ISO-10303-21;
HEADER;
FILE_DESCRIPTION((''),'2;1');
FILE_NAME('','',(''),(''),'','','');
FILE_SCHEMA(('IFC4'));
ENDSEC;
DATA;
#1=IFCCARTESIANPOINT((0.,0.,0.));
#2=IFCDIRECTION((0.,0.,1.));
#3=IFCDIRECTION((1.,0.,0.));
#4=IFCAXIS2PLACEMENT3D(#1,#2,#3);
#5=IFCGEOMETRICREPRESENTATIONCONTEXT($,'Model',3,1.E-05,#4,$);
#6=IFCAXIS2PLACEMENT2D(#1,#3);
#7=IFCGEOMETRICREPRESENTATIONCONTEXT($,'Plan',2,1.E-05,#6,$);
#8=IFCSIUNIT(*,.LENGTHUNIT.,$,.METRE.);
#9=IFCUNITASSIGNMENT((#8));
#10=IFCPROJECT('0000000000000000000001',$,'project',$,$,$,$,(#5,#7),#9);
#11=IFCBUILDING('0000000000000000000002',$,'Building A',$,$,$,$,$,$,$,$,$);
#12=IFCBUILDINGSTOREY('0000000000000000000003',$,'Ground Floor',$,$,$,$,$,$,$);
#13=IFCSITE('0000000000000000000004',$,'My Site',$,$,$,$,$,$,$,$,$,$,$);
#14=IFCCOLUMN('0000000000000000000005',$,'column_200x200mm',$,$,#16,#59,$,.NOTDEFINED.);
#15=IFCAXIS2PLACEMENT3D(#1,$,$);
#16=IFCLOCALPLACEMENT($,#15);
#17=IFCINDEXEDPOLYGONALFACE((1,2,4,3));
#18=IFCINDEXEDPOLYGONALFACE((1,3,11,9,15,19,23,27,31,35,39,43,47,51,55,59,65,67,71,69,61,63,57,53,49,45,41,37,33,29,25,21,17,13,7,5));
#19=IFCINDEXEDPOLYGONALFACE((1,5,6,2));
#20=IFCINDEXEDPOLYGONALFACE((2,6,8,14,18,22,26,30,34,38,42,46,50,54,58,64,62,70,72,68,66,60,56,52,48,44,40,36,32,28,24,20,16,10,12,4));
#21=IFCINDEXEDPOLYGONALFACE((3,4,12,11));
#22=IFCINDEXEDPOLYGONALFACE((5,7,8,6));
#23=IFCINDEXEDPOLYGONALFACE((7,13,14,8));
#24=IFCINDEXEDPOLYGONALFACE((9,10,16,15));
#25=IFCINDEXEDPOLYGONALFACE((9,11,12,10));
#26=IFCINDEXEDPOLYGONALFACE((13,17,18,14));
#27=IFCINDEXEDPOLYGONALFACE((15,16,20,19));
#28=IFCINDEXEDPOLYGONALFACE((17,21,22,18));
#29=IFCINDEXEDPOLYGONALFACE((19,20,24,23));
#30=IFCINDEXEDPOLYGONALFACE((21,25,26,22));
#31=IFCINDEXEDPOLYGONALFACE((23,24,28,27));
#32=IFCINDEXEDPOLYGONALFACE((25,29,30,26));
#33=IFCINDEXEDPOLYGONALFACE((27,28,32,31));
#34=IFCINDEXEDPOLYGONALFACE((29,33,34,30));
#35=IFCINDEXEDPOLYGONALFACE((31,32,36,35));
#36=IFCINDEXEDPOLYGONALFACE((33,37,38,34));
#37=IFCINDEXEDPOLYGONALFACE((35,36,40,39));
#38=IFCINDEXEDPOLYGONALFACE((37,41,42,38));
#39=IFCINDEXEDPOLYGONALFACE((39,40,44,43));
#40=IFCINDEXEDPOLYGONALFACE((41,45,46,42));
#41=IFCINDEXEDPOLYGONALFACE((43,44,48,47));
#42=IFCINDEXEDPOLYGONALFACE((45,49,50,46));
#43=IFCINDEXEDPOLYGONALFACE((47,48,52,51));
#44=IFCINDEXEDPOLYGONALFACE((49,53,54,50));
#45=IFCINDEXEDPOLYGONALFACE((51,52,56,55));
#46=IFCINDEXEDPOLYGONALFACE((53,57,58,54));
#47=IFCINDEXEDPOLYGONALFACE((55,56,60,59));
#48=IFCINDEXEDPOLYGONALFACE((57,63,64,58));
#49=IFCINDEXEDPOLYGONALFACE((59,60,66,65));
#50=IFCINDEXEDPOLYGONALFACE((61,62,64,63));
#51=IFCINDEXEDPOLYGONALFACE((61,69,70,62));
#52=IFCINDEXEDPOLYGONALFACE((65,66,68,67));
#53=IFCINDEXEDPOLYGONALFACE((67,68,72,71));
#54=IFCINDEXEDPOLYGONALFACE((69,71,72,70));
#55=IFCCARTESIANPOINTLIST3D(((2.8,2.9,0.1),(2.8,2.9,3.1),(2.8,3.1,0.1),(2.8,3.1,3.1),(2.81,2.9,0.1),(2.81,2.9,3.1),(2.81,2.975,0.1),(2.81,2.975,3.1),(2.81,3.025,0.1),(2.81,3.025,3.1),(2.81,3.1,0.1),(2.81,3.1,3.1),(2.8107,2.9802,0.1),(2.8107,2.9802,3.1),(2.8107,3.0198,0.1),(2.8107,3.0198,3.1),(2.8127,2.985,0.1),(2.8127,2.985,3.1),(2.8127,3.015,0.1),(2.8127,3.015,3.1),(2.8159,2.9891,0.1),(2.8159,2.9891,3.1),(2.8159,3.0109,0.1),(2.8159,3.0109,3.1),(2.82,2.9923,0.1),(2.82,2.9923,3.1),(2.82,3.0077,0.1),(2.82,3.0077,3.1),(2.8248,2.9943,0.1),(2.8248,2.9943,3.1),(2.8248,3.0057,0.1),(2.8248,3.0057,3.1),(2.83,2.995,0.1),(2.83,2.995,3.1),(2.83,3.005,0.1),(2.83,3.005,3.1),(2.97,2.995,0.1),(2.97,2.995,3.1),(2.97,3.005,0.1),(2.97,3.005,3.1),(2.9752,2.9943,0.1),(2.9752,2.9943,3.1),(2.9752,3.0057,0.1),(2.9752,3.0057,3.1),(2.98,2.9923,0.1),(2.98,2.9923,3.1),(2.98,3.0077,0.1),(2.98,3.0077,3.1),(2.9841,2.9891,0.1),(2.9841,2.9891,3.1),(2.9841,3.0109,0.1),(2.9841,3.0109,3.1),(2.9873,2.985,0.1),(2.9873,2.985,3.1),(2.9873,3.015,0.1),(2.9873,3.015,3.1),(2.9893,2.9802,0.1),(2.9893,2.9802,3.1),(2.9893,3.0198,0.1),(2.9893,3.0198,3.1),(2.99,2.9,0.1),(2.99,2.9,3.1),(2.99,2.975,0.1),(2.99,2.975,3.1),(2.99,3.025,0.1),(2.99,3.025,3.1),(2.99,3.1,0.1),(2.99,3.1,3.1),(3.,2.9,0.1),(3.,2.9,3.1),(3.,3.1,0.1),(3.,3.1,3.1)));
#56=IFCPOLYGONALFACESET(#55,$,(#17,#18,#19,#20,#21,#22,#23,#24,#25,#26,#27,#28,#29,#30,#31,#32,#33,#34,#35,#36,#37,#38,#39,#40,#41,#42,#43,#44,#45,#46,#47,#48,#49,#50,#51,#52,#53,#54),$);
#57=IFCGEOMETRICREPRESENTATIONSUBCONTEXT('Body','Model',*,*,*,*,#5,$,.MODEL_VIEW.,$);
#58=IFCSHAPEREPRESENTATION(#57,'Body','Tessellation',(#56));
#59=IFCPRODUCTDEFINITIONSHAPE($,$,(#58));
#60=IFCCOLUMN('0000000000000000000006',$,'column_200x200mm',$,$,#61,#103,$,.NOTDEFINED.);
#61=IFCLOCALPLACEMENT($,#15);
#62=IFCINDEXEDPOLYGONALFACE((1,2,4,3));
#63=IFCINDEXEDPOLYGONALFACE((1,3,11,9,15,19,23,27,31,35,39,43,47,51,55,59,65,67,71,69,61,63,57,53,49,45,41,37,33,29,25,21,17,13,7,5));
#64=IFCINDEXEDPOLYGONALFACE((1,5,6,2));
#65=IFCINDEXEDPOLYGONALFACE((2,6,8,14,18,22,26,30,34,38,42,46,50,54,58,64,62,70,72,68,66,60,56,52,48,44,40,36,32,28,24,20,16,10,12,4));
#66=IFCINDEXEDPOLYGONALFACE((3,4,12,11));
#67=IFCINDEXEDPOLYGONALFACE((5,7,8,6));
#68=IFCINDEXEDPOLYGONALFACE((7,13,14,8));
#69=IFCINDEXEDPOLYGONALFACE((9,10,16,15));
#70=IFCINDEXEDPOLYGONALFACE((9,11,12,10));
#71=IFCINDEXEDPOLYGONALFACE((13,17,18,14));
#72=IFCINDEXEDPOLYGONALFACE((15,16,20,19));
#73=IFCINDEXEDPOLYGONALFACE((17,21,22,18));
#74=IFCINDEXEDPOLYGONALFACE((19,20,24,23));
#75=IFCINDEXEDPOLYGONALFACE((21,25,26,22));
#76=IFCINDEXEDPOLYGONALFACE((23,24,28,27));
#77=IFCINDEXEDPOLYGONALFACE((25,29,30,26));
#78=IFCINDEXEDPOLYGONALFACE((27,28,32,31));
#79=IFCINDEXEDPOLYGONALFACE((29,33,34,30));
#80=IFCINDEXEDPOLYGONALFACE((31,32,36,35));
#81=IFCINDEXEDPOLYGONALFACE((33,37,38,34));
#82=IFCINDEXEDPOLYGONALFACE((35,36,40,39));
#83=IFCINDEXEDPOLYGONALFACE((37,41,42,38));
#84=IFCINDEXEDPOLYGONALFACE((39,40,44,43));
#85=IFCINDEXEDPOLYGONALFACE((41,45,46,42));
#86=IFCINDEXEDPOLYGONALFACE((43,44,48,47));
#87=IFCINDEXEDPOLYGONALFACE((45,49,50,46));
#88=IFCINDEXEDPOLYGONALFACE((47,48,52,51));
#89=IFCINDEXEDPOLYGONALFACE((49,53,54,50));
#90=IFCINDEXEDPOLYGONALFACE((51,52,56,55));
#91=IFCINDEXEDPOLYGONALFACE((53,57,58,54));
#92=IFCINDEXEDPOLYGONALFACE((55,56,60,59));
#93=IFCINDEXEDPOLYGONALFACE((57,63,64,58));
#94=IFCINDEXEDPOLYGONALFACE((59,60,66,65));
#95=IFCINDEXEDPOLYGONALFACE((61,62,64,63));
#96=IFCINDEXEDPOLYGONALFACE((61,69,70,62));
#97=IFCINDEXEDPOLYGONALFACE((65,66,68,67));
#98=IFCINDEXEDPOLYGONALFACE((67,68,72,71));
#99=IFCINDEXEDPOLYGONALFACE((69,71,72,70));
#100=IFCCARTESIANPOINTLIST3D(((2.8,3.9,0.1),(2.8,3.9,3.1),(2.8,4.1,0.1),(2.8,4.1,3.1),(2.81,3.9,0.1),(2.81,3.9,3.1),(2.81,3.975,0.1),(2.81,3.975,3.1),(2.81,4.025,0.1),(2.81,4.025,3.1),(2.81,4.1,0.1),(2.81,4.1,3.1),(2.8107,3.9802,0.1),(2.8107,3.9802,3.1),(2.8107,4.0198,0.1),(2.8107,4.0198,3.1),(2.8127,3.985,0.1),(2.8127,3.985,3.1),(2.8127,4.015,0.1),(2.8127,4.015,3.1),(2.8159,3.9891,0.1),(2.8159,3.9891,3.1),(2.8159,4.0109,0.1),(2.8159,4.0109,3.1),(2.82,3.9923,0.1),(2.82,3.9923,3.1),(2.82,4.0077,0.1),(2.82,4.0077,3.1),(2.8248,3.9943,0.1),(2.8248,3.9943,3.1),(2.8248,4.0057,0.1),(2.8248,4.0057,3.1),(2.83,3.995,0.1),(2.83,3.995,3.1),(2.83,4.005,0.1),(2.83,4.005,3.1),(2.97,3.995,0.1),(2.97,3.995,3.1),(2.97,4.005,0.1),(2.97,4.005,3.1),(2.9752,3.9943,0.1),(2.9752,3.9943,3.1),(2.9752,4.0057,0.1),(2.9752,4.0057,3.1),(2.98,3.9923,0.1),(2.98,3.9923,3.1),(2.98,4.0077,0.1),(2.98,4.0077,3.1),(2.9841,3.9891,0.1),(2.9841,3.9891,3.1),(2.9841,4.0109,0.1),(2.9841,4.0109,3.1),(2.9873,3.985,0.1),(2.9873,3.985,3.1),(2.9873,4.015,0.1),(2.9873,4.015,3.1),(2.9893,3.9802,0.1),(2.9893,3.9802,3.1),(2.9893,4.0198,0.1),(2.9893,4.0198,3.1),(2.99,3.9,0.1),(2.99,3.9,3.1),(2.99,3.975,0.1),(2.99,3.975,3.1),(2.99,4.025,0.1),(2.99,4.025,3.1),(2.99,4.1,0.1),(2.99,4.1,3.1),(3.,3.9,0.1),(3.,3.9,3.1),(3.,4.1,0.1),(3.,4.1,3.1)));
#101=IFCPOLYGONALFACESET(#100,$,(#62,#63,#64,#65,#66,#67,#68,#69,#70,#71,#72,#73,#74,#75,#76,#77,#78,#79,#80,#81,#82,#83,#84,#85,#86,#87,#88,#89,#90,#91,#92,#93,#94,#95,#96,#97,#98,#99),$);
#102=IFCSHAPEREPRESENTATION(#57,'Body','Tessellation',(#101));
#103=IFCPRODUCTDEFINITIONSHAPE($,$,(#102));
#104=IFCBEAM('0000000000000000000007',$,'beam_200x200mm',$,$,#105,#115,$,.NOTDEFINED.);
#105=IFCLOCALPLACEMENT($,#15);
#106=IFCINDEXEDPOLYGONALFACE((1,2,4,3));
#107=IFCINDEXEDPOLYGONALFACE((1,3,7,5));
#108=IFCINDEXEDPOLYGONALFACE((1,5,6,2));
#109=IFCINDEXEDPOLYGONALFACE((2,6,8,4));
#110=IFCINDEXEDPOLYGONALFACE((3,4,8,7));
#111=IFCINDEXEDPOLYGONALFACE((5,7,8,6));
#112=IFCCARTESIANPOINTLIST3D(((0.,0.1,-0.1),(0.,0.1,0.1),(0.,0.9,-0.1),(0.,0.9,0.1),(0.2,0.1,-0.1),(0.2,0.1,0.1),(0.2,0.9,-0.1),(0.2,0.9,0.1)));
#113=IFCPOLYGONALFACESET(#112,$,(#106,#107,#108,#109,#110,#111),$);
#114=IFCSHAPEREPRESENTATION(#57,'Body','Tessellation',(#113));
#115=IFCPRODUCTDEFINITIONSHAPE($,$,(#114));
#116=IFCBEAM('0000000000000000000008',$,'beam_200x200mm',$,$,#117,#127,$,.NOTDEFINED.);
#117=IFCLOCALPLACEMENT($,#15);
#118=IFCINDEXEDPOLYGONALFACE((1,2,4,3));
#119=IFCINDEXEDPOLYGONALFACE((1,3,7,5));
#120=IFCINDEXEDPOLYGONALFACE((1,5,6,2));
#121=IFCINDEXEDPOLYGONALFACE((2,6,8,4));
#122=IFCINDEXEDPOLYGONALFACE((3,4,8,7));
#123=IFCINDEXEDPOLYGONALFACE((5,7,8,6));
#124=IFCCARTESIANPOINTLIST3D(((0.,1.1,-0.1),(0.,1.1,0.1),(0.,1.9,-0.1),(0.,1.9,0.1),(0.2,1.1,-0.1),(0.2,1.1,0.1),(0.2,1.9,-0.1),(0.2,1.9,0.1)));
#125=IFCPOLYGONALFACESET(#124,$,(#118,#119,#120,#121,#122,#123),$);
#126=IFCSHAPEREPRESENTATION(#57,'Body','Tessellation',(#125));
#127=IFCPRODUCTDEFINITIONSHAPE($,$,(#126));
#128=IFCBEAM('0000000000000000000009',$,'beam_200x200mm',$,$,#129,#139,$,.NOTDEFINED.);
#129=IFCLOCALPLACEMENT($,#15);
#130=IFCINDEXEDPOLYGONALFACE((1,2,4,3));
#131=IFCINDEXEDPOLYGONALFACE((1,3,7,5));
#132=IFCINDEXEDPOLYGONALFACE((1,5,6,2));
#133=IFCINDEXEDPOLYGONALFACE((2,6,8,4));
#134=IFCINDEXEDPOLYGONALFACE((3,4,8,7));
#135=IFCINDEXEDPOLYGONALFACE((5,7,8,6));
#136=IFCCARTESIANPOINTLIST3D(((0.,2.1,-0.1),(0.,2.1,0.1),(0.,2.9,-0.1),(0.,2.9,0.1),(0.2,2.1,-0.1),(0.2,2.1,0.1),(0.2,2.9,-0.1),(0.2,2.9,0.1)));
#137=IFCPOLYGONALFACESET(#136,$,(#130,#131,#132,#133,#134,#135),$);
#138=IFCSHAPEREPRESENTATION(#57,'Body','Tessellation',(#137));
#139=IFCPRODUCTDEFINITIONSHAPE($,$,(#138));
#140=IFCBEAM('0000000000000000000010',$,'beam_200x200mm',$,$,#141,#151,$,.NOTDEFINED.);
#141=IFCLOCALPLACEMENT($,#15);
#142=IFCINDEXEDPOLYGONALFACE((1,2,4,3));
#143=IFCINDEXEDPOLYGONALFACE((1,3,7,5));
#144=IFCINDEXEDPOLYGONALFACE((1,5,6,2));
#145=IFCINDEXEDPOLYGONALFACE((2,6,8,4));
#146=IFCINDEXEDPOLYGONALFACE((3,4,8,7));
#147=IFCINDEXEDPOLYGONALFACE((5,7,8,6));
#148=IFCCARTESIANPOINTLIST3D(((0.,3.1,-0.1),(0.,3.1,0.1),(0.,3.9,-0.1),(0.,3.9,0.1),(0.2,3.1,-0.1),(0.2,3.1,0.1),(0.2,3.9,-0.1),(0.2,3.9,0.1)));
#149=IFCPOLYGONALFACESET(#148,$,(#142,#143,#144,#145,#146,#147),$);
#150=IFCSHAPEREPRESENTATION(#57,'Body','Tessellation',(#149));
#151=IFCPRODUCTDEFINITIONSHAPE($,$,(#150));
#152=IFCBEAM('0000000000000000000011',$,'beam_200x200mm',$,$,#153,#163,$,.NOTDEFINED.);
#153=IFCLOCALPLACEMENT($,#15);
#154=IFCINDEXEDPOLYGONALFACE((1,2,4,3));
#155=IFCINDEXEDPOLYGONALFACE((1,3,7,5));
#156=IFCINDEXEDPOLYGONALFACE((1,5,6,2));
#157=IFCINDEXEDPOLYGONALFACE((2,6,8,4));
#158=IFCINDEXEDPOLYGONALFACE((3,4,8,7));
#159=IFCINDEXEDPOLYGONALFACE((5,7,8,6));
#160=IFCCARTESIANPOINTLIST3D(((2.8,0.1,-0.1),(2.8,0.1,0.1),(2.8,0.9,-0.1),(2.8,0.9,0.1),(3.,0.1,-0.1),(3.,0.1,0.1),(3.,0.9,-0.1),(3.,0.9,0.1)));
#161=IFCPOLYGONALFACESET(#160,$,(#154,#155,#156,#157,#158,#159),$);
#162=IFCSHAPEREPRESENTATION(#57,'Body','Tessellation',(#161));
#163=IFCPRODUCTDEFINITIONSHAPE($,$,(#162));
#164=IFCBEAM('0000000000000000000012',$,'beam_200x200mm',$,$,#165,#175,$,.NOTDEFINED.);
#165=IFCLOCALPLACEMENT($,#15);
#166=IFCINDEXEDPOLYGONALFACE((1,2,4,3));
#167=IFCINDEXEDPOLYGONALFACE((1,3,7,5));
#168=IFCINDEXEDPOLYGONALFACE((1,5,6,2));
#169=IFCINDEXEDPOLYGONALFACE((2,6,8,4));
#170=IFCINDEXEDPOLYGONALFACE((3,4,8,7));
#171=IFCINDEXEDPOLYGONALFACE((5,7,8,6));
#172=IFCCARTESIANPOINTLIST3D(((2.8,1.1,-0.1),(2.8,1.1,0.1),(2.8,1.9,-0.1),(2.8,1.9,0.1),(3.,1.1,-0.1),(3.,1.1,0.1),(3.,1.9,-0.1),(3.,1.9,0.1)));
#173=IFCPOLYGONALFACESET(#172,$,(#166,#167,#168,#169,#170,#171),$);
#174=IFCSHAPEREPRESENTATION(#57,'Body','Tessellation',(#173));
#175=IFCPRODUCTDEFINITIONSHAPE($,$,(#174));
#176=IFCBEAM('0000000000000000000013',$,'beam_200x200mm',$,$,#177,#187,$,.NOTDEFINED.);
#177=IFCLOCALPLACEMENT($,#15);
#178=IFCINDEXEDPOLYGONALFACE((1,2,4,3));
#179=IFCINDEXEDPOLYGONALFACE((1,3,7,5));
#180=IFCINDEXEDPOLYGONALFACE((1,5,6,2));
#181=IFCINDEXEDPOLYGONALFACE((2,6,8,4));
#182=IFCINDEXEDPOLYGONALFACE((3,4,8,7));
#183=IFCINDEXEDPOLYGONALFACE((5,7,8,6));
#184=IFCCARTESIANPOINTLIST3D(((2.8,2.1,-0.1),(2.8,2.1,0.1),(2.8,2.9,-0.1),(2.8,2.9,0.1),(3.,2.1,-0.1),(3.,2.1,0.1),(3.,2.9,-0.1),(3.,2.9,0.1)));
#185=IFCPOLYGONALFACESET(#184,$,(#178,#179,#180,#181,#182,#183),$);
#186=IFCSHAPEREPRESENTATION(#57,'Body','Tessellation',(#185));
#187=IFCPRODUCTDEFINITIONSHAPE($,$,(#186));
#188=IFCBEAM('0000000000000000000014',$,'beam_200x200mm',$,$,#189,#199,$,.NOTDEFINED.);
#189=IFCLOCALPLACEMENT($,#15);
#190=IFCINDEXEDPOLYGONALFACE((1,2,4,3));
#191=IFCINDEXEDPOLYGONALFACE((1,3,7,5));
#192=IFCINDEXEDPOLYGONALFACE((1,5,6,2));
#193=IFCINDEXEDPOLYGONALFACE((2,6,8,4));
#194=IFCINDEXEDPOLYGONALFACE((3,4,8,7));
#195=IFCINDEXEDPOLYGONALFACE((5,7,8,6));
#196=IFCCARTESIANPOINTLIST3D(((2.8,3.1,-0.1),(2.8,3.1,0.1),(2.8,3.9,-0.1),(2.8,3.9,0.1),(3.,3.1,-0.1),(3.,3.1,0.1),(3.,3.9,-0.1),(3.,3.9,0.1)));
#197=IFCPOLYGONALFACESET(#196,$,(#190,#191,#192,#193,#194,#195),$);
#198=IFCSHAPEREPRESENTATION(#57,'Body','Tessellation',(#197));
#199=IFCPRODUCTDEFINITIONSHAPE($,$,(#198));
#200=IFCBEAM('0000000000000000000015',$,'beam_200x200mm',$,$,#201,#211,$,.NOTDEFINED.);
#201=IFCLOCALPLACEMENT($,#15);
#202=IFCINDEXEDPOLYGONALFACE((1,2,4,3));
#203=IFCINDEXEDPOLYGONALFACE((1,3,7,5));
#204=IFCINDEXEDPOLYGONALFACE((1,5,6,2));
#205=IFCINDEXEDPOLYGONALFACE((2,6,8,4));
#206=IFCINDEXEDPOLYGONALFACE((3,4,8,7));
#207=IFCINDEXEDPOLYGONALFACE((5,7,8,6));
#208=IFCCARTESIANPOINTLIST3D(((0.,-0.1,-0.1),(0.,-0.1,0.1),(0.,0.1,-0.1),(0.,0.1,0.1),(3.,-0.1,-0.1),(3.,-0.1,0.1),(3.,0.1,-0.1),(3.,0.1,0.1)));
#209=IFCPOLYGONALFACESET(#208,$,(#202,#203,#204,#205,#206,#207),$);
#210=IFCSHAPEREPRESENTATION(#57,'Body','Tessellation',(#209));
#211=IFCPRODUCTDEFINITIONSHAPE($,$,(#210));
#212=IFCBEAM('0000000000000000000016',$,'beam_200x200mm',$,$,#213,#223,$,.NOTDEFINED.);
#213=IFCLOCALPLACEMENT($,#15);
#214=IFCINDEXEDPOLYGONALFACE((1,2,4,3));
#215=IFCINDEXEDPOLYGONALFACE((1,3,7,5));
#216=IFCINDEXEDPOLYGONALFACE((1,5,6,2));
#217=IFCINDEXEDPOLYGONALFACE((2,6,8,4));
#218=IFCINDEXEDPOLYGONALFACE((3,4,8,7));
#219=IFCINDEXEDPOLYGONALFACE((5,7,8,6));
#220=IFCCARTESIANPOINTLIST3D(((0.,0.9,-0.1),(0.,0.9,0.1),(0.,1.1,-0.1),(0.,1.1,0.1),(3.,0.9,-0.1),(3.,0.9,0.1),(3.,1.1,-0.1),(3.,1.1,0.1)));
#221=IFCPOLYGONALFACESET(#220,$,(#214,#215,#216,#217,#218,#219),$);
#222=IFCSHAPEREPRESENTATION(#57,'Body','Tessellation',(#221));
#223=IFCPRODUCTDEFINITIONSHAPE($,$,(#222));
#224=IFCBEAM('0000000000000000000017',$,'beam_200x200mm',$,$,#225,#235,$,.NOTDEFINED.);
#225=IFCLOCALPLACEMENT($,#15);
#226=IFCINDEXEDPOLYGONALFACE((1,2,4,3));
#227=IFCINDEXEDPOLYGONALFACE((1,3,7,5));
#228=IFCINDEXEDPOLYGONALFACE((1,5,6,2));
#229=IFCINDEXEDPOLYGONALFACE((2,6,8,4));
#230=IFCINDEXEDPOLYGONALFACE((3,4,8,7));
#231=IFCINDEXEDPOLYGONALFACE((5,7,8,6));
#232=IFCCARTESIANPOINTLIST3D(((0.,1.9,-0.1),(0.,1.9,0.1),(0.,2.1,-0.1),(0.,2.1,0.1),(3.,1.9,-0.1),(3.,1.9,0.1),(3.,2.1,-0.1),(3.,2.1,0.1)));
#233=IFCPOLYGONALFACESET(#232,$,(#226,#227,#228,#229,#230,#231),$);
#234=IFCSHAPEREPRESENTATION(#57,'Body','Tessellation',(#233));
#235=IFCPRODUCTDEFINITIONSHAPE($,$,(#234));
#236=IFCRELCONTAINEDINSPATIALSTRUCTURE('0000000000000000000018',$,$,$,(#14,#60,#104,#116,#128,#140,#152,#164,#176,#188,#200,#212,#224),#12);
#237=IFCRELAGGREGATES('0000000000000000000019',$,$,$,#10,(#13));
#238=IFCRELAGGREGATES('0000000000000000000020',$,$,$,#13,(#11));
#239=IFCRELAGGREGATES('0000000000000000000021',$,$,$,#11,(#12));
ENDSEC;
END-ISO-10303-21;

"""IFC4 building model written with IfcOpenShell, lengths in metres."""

from ifc_helpers import new_model, entity, si_unit, frame, frame_2d, origin_with_axes, place, context, subcontext, project, spatial, rectangle, extrude, element, save


model = new_model("IFC4")

# Units and contexts
model_context = context("Model", 3, precision=1e-05, world=origin_with_axes())
plan_context = context("Plan", 2, precision=1e-05, world=frame_2d((0.0, 0.0, 0.0), x_axis=(1.0, 0.0, 0.0)))
body_context = subcontext(model_context, "Body", "Model", "MODEL_VIEW")
ifc_project = project(units=[si_unit("LENGTHUNIT", "METRE")], contexts=[model_context, plan_context])

# Site, building, storey
site = spatial("IfcSite", under=ifc_project, Name="My Site")
building = spatial("IfcBuilding", under=site, Name="Building A")
storey = spatial("IfcBuildingStorey", under=building, Name="Ground Floor")

# Columns
for number, where, z_axis, x_axis, name in (
    (1, (2.9, 3.0, 0.1), (0.0, 0.0, 1.0), (0.0, 1.0, 0.0), "column_200x200mm"),
    (2, (2.9, 4.0, 0.1), (0.0, 0.0, 1.0), (0.0, 1.0, 0.0), "column_200x200mm"),
):
    element("IfcColumn", number, at=place(None, frame(where, z_axis=z_axis, x_axis=x_axis)), inside=storey, Name=name, PredefinedType="NOTDEFINED", context=body_context, shape_type="SweptSolid", body=[
        extrude(entity("IfcIShapeProfileDef", None, None, None, 0.2, 0.2, 0.01, 0.01, 0.02), origin_with_axes(), (0.0, 0.0, 1.0), 3.0),
    ])

# Beams
for number, where, z_axis, x_axis, name in (
    (3, (0.1, 0.1, 0.0), (0.0, 1.0, 0.0), (0.0, 1.0, 1.0), "beam_200x200mm"),
    (4, (0.1, 1.1, 0.0), (0.0, 1.0, 0.0), (0.0, 1.0, 1.0), "beam_200x200mm"),
    (5, (0.1, 2.1, 0.0), (0.0, 1.0, 0.0), (0.0, 1.0, 1.0), "beam_200x200mm"),
    (6, (0.1, 3.1, 0.0), (0.0, 1.0, 0.0), (0.0, 1.0, 1.0), "beam_200x200mm"),
    (7, (2.9, 0.1, 0.0), (0.0, 1.0, 0.0), (0.0, 1.0, 1.0), "beam_200x200mm"),
    (8, (2.9, 1.1, 0.0), (0.0, 1.0, 0.0), (0.0, 1.0, 1.0), "beam_200x200mm"),
    (9, (2.9, 2.1, 0.0), (0.0, 1.0, 0.0), (0.0, 1.0, 1.0), "beam_200x200mm"),
    (10, (2.9, 3.1, 0.0), (0.0, 1.0, 0.0), (0.0, 1.0, 1.0), "beam_200x200mm"),
):
    element("IfcBeam", number, at=place(None, frame(where, z_axis=z_axis, x_axis=x_axis)), inside=storey, Name=name, PredefinedType="NOTDEFINED", context=body_context, shape_type="SweptSolid", body=[
        extrude(rectangle(XDim=0.2, YDim=0.2), origin_with_axes(), (0.0, 0.0, 1.0), 0.8),
    ])
for number, where, z_axis, x_axis, name in (
    (11, (0.0, 0.0, 0.0), (1.0, 0.0, 0.0), (0.0, 0.0, 1.0), "beam_200x200mm"),
    (12, (0.0, 1.0, 0.0), (1.0, 0.0, 0.0), (0.0, 0.0, 1.0), "beam_200x200mm"),
    (13, (0.0, 2.0, 0.0), (1.0, 0.0, 0.0), (0.0, 0.0, 1.0), "beam_200x200mm"),
):
    element("IfcBeam", number, at=place(None, frame(where, z_axis=z_axis, x_axis=x_axis)), inside=storey, Name=name, PredefinedType="NOTDEFINED", context=body_context, shape_type="SweptSolid", body=[
        extrude(rectangle(XDim=0.2, YDim=0.2), origin_with_axes(), (0.0, 0.0, 1.0), 3.0),
    ])

save(model, "model.ifc")
